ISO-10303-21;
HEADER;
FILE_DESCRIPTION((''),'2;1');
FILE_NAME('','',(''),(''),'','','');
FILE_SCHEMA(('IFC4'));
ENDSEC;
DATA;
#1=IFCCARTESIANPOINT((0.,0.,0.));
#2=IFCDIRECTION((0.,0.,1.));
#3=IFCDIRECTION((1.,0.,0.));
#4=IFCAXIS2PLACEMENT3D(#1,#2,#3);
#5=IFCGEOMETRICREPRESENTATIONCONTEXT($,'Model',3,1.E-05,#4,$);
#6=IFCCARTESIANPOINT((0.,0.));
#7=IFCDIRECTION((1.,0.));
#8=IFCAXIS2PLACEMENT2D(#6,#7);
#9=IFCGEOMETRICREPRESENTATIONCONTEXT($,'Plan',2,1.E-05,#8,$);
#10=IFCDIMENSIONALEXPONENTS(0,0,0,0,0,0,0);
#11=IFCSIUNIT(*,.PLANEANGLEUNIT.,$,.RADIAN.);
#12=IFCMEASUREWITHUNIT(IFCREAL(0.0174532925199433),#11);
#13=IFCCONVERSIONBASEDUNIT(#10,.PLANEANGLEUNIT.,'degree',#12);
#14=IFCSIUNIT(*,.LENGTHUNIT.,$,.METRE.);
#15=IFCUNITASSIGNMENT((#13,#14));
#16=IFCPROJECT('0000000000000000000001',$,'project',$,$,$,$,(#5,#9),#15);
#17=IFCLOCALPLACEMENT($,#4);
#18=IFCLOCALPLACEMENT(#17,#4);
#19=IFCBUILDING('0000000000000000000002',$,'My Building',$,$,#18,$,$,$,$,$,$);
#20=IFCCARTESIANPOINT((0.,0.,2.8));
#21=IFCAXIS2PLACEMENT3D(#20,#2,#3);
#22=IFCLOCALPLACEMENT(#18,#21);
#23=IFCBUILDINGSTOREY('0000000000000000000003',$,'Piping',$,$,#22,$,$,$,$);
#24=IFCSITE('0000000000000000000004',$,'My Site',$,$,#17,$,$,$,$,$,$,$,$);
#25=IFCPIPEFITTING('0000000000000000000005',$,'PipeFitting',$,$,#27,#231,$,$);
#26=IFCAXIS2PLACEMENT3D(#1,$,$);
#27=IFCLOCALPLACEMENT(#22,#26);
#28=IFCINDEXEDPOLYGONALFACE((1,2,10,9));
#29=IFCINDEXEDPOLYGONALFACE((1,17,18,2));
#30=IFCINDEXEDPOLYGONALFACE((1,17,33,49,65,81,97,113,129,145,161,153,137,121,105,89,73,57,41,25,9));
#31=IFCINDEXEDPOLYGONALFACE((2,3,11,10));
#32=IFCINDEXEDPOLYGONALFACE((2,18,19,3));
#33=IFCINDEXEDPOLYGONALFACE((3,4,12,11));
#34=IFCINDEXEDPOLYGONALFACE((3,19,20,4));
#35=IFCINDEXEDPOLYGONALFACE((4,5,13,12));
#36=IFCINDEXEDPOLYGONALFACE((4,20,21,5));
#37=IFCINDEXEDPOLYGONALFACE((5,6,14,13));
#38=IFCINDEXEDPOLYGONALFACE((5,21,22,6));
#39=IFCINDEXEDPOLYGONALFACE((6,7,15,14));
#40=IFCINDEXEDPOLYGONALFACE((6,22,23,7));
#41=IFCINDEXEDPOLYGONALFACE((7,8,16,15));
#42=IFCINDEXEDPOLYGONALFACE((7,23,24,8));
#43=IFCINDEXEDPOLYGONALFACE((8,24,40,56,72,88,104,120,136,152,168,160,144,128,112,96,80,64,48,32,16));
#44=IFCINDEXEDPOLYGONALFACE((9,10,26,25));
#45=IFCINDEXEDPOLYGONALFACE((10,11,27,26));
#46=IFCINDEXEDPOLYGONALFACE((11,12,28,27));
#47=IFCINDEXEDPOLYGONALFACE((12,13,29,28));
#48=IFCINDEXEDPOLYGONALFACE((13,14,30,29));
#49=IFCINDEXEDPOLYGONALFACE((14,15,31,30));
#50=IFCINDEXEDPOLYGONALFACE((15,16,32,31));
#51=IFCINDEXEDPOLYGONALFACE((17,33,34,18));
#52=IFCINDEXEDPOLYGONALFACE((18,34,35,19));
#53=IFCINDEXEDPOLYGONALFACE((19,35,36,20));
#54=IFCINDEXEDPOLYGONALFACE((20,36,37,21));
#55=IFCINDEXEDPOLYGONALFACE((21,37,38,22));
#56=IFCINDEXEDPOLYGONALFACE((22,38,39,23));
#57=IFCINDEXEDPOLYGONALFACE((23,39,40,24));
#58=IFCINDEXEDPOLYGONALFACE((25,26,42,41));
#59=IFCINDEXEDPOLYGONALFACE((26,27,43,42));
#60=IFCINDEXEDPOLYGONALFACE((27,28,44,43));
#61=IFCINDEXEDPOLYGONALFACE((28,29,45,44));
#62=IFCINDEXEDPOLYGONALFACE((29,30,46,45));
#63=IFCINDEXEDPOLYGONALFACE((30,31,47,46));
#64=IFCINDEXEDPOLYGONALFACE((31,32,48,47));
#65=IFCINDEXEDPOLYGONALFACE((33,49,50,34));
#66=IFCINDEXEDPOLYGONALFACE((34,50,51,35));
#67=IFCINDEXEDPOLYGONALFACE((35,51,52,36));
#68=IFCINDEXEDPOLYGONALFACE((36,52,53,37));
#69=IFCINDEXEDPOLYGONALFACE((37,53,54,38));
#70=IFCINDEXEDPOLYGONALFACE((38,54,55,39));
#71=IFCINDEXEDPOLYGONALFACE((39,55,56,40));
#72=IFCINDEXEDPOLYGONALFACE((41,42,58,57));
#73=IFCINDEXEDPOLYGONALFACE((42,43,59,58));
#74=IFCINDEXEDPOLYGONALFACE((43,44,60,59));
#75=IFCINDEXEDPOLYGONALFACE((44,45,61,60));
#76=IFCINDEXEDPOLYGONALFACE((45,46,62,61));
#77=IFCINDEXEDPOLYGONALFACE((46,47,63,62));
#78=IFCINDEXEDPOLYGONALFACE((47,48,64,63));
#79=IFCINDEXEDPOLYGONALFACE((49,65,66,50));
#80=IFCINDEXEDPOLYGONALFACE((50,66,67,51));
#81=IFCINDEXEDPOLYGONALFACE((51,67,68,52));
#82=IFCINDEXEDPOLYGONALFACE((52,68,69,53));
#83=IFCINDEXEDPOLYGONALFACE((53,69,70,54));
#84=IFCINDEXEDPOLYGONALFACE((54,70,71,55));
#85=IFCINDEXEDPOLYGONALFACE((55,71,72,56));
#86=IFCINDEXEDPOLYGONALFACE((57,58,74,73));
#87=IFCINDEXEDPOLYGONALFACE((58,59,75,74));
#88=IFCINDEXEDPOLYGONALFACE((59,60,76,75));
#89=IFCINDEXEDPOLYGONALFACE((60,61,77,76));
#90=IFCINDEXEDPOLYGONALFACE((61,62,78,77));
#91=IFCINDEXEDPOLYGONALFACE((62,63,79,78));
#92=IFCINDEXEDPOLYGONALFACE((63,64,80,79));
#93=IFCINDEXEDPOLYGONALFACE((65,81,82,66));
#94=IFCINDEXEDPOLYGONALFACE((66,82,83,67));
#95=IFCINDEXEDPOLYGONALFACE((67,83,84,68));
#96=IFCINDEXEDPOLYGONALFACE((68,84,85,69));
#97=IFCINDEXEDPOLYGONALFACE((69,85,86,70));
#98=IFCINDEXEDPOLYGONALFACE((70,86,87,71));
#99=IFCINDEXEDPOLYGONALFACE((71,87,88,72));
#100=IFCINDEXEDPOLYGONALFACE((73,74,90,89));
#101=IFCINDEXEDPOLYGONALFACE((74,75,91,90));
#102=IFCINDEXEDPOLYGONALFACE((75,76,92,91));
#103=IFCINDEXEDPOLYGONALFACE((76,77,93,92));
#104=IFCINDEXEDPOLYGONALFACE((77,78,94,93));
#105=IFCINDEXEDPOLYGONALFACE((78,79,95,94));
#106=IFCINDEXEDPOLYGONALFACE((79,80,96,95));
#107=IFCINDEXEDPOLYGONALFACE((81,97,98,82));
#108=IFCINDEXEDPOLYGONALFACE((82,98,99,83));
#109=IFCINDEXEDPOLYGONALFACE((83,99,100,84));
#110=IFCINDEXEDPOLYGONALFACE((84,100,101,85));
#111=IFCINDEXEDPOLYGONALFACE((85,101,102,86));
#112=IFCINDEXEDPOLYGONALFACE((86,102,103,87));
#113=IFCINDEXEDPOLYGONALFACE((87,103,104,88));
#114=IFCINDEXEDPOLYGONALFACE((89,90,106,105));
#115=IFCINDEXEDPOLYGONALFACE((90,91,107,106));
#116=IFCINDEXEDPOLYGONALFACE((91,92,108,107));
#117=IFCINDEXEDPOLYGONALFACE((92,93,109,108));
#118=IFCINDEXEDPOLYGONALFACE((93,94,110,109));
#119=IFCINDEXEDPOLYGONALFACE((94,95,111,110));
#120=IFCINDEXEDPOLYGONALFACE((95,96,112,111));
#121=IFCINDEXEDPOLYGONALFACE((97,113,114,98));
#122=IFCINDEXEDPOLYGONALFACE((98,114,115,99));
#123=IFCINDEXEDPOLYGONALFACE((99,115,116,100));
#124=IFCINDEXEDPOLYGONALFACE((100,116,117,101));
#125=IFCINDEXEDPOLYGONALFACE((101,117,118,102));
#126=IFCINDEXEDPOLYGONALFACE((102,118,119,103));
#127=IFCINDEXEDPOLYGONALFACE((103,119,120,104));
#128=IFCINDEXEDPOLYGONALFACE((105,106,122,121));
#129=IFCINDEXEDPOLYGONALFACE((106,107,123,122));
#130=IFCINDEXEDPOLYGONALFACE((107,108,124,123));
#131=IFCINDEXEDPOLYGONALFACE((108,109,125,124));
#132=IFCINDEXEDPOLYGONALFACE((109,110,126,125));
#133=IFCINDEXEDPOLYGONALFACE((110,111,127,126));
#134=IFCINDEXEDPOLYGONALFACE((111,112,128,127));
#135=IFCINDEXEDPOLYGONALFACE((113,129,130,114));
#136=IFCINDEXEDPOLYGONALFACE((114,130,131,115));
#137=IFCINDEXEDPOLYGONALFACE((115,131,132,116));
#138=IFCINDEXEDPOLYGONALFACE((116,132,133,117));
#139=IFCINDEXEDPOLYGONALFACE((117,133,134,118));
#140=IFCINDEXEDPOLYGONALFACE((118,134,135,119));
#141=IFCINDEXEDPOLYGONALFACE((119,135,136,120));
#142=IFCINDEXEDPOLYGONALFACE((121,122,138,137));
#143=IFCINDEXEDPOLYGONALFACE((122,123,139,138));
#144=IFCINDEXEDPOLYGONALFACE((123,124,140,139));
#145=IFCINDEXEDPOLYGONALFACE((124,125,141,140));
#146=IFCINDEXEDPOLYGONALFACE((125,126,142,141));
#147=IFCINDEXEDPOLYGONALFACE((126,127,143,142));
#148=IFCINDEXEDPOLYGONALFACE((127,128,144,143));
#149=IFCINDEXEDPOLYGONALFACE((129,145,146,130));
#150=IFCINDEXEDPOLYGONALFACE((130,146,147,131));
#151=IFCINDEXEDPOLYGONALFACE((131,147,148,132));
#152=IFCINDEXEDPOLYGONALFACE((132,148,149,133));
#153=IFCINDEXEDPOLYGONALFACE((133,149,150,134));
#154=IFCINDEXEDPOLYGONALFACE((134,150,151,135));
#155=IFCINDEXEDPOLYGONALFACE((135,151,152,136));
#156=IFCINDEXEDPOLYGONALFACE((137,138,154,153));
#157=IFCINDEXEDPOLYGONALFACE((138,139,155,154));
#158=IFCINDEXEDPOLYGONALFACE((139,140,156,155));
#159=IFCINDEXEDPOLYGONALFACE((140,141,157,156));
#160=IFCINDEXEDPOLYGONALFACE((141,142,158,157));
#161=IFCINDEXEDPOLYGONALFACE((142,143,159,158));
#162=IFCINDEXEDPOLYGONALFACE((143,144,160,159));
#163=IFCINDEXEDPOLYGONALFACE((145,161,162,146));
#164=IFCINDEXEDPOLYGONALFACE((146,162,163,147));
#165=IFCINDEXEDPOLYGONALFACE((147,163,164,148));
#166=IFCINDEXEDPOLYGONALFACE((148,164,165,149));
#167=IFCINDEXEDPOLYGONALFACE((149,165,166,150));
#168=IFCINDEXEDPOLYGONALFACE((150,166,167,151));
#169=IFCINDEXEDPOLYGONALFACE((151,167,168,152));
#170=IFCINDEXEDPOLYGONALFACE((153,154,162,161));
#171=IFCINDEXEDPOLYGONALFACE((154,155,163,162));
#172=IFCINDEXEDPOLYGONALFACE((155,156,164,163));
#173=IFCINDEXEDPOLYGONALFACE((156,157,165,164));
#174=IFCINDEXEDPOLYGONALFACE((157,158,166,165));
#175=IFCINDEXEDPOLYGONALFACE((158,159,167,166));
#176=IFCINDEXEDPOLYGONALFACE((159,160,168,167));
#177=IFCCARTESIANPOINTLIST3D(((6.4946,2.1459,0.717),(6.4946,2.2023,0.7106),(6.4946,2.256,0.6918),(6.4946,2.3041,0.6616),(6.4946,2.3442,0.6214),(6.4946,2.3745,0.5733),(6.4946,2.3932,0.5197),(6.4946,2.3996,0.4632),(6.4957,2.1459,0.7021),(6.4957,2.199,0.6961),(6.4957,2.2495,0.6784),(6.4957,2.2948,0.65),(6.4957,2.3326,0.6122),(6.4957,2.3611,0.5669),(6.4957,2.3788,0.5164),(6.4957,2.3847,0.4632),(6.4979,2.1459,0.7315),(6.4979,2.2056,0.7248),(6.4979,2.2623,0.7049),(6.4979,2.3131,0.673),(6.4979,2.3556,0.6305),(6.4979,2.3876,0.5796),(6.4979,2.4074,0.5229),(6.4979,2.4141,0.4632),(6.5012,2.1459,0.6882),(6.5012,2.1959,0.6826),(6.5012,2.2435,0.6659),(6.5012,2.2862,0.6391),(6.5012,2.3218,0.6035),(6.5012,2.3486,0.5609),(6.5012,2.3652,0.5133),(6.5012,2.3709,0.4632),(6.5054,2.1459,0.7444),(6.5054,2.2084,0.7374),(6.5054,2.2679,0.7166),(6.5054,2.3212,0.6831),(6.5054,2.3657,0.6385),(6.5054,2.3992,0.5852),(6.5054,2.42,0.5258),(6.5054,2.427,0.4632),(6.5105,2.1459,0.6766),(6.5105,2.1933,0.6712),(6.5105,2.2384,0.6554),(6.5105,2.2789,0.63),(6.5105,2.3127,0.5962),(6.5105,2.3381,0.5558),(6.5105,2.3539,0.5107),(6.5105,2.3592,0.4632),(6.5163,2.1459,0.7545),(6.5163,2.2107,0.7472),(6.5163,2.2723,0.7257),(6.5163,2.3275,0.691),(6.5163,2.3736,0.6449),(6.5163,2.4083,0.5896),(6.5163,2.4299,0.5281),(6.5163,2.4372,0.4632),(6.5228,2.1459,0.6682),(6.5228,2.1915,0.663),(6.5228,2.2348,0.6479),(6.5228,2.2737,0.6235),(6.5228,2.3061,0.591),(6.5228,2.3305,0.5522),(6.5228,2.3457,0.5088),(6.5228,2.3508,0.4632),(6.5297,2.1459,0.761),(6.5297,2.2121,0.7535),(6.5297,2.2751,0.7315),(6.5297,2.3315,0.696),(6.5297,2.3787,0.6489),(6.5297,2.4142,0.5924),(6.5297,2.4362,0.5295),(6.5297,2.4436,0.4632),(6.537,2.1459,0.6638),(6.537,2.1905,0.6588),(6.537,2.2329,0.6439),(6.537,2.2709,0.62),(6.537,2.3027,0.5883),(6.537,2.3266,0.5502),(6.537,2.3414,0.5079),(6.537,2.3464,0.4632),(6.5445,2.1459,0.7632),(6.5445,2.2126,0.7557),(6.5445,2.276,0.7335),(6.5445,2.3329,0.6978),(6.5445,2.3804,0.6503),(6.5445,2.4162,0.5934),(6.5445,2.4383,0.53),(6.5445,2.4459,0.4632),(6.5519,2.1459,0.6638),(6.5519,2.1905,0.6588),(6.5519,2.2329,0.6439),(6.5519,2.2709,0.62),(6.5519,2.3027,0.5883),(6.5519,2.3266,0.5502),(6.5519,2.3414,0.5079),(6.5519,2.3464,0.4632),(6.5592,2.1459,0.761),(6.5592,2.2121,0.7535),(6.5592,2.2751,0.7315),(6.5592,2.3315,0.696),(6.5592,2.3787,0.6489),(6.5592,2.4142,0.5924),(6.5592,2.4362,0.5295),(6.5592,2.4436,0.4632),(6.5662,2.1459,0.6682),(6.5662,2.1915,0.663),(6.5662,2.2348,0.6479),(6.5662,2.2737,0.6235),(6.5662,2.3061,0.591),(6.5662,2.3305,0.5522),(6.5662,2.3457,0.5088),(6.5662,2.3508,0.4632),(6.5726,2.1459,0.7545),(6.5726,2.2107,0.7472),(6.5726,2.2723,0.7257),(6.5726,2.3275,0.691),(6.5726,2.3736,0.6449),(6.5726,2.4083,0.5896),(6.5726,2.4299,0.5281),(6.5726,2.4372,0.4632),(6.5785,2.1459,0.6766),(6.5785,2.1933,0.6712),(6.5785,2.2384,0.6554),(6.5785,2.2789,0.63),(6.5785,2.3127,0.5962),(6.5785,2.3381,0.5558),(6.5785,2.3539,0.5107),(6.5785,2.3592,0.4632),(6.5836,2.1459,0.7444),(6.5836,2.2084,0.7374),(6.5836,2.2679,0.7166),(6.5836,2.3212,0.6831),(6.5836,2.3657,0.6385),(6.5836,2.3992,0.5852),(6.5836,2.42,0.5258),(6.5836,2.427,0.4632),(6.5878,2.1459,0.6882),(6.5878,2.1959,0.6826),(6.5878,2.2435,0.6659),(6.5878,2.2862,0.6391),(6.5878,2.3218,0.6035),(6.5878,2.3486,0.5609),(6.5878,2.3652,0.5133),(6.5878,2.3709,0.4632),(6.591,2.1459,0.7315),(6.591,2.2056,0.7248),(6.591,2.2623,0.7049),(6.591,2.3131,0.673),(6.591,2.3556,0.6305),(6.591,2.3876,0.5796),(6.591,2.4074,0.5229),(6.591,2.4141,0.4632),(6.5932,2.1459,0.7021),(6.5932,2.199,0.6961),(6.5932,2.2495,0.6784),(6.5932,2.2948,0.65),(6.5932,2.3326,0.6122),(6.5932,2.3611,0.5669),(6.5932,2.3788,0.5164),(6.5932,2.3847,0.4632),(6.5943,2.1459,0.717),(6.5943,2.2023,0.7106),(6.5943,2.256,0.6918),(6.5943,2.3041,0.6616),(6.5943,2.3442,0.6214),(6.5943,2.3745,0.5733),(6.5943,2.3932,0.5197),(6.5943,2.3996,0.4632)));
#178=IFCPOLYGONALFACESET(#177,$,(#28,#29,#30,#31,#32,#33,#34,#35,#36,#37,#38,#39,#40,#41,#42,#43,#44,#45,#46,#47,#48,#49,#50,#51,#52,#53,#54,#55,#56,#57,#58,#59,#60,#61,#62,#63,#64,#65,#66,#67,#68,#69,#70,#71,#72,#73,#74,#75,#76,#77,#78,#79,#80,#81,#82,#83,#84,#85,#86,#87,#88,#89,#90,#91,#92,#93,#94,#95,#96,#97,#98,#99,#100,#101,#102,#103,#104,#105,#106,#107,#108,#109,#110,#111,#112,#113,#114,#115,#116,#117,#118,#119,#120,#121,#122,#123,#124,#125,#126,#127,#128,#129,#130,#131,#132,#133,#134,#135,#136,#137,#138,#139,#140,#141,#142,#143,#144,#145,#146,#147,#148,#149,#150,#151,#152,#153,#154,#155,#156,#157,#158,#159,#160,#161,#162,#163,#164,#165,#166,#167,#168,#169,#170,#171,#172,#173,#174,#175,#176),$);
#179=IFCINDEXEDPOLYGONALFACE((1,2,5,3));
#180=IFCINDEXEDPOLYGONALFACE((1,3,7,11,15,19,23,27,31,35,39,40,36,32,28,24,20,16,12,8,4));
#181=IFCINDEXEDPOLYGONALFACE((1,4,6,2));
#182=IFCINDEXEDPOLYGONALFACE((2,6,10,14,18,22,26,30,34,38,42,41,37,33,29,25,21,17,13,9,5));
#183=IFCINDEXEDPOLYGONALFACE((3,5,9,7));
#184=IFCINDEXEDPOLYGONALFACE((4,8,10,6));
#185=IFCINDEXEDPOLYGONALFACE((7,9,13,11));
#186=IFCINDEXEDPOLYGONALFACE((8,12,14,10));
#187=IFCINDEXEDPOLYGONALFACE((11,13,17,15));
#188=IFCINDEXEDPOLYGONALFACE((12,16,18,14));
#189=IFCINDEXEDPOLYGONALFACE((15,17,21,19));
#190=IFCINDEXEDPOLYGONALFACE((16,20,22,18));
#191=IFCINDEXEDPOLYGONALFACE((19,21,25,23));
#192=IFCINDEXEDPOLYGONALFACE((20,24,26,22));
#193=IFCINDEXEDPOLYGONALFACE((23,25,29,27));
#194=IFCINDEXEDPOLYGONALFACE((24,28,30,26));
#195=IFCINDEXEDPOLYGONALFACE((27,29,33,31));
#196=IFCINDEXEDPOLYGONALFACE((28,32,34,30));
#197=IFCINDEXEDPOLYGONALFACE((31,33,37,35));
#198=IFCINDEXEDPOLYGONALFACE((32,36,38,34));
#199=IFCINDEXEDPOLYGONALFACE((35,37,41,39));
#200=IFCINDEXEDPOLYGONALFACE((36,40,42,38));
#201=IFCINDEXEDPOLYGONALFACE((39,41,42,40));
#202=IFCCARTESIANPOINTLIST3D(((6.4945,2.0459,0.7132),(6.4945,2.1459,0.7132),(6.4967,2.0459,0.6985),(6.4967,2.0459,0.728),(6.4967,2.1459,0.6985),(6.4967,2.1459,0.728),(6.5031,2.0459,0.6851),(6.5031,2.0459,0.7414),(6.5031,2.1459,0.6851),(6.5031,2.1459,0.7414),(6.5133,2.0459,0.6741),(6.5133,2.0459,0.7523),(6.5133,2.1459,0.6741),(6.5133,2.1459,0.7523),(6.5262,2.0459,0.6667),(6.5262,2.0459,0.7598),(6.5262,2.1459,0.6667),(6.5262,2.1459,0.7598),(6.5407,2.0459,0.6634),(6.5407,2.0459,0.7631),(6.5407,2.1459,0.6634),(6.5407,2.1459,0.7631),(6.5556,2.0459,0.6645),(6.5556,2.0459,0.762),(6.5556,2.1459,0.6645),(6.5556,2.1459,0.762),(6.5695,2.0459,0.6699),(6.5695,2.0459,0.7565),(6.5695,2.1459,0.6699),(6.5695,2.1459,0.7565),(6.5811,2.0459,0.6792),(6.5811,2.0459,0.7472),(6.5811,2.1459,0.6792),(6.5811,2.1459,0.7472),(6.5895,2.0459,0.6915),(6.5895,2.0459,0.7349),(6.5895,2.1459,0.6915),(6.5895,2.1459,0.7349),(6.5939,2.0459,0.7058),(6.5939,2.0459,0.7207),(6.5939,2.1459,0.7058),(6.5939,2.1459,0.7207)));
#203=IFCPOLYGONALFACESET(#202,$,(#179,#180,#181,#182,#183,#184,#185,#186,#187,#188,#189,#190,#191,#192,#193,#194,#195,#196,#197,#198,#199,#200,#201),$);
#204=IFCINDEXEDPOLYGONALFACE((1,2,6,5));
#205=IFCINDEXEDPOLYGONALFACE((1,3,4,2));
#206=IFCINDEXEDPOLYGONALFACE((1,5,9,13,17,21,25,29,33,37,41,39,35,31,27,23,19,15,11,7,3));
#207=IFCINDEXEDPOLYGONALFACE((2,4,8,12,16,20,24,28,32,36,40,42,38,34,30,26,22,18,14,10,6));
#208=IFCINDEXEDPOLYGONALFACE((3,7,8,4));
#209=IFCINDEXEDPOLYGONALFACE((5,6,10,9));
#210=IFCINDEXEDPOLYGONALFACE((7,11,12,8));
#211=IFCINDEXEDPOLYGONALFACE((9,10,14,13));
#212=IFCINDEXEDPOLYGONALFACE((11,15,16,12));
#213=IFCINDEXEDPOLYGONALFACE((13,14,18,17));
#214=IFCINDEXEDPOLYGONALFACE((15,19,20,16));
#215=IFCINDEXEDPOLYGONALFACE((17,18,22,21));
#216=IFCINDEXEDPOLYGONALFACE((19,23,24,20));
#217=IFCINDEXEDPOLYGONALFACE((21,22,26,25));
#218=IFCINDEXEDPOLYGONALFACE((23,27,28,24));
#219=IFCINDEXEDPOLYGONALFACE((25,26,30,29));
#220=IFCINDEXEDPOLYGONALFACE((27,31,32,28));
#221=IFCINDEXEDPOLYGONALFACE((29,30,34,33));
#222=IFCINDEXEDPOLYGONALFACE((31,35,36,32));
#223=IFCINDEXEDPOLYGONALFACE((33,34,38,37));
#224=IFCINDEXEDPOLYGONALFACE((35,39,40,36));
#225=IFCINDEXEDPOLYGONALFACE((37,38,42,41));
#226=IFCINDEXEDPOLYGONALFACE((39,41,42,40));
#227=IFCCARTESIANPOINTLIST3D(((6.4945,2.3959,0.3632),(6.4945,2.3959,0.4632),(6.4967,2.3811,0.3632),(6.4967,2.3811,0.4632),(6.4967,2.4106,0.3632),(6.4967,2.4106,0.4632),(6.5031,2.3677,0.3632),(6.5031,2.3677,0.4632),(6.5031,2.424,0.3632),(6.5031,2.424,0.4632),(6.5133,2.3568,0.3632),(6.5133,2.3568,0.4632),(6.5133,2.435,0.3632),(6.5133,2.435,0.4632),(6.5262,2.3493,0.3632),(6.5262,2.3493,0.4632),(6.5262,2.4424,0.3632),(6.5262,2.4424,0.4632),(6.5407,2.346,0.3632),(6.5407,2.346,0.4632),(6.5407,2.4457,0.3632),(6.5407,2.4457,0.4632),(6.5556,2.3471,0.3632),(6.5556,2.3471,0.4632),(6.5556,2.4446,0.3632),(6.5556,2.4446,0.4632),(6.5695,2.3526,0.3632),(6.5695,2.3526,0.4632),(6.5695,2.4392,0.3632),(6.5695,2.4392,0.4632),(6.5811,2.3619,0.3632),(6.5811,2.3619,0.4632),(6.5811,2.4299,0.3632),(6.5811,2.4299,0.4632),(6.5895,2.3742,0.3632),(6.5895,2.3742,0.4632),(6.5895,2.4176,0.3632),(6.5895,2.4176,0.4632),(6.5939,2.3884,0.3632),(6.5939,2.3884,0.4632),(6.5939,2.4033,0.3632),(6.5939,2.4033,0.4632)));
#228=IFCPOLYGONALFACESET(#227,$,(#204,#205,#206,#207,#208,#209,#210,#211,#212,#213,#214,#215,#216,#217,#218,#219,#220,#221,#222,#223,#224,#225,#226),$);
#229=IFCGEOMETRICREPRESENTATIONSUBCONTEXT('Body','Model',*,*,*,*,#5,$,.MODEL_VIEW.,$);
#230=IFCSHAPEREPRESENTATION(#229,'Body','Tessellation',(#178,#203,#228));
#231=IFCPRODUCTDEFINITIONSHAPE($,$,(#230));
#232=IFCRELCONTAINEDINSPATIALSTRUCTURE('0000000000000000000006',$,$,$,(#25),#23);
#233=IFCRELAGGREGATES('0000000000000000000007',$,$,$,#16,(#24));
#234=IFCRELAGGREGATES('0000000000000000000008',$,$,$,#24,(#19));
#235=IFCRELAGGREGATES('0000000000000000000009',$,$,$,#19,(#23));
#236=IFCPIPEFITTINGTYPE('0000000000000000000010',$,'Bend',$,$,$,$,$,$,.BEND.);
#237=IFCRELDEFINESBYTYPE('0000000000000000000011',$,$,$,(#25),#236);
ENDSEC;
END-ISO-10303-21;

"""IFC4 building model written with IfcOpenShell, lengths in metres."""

from ifc_helpers import new_model, entity, si_unit, converted_unit, frame, origin_with_axes, origin_2d_with_axis, place, context, subcontext, project, spatial, circle, extrude, source, transform, mapped, type_object, type_shapes, element, save


model = new_model("IFC4")

# Units and contexts
model_context = context("Model", 3, precision=1e-05, world=origin_with_axes())
plan_context = context("Plan", 2, precision=1e-05, world=origin_2d_with_axis())
body_context = subcontext(model_context, "Body", "Model", "MODEL_VIEW")
ifc_project = project(units=[converted_unit("PLANEANGLEUNIT", "degree", entity("IfcReal", 0.0174532925199433), si_unit("PLANEANGLEUNIT", "RADIAN"), dimensions=[0, 0, 0, 0, 0, 0, 0]), si_unit("LENGTHUNIT", "METRE")], contexts=[model_context, plan_context])

# Site, building, storey
site_placement = place(None, origin_with_axes())
site = spatial("IfcSite", under=ifc_project, at=site_placement, Name="My Site")
building_placement = place(site_placement, origin_with_axes())
building = spatial("IfcBuilding", under=site, at=building_placement, Name="My Building")
storey_placement = place(building_placement, frame((0.0, 0.0, 2.8), z_axis=(0.0, 0.0, 1.0), x_axis=(1.0, 0.0, 0.0)))
storey = spatial("IfcBuildingStorey", under=building, at=storey_placement, Name="Piping")

# Pipe fitting
pipe_fitting_type_1 = type_object("IfcPipeFittingType", Name="Bend", PredefinedType="BEND")
shared_shape = source(origin_with_axes(), body_context, "Body", "SolidModel", [
    entity("IfcSweptDiskSolid", entity("IfcIndexedPolyCurve", entity("IfcCartesianPointList3D", [[0.0, 0.0, 0.1], [0.0, -0.0732, 0.2768], [0.0, -0.25, 0.35]]), [entity("IfcArcIndex", [1, 2, 3])]), 0.05),
    extrude(circle(Radius=0.05), origin_with_axes(), (0.0, 0.0, 1.0), 0.1),
    extrude(circle(Radius=0.05), frame((0.0, -0.25, 0.35), z_axis=(0.0, -1.0, 0.0), x_axis=(1.0, 0.0, 0.0)), (0.0, 0.0, 1.0), 0.1),
])
type_shapes(pipe_fitting_type_1, [shared_shape])
for number, where, z_axis, x_axis, name in (
    (1, (6.5445, 2.0459, 0.7132), (0.0, 1.0, 0.0), (-1.0, 0.0, 0.0), "PipeFitting"),
):
    element("IfcPipeFitting", number, at=place(storey_placement, frame(where, z_axis=z_axis, x_axis=x_axis)), inside=storey, type_object=pipe_fitting_type_1, Name=name, context=body_context, shape_type="MappedRepresentation", body=[
        mapped(shared_shape, transform((0.0, 0.0, 0.0), x_axis=(1.0, 0.0, 0.0), y_axis=(0.0, 1.0, 0.0), z_axis=(0.0, 0.0, 1.0), scale=1.0)),
    ])

save(model, "model.ifc")
